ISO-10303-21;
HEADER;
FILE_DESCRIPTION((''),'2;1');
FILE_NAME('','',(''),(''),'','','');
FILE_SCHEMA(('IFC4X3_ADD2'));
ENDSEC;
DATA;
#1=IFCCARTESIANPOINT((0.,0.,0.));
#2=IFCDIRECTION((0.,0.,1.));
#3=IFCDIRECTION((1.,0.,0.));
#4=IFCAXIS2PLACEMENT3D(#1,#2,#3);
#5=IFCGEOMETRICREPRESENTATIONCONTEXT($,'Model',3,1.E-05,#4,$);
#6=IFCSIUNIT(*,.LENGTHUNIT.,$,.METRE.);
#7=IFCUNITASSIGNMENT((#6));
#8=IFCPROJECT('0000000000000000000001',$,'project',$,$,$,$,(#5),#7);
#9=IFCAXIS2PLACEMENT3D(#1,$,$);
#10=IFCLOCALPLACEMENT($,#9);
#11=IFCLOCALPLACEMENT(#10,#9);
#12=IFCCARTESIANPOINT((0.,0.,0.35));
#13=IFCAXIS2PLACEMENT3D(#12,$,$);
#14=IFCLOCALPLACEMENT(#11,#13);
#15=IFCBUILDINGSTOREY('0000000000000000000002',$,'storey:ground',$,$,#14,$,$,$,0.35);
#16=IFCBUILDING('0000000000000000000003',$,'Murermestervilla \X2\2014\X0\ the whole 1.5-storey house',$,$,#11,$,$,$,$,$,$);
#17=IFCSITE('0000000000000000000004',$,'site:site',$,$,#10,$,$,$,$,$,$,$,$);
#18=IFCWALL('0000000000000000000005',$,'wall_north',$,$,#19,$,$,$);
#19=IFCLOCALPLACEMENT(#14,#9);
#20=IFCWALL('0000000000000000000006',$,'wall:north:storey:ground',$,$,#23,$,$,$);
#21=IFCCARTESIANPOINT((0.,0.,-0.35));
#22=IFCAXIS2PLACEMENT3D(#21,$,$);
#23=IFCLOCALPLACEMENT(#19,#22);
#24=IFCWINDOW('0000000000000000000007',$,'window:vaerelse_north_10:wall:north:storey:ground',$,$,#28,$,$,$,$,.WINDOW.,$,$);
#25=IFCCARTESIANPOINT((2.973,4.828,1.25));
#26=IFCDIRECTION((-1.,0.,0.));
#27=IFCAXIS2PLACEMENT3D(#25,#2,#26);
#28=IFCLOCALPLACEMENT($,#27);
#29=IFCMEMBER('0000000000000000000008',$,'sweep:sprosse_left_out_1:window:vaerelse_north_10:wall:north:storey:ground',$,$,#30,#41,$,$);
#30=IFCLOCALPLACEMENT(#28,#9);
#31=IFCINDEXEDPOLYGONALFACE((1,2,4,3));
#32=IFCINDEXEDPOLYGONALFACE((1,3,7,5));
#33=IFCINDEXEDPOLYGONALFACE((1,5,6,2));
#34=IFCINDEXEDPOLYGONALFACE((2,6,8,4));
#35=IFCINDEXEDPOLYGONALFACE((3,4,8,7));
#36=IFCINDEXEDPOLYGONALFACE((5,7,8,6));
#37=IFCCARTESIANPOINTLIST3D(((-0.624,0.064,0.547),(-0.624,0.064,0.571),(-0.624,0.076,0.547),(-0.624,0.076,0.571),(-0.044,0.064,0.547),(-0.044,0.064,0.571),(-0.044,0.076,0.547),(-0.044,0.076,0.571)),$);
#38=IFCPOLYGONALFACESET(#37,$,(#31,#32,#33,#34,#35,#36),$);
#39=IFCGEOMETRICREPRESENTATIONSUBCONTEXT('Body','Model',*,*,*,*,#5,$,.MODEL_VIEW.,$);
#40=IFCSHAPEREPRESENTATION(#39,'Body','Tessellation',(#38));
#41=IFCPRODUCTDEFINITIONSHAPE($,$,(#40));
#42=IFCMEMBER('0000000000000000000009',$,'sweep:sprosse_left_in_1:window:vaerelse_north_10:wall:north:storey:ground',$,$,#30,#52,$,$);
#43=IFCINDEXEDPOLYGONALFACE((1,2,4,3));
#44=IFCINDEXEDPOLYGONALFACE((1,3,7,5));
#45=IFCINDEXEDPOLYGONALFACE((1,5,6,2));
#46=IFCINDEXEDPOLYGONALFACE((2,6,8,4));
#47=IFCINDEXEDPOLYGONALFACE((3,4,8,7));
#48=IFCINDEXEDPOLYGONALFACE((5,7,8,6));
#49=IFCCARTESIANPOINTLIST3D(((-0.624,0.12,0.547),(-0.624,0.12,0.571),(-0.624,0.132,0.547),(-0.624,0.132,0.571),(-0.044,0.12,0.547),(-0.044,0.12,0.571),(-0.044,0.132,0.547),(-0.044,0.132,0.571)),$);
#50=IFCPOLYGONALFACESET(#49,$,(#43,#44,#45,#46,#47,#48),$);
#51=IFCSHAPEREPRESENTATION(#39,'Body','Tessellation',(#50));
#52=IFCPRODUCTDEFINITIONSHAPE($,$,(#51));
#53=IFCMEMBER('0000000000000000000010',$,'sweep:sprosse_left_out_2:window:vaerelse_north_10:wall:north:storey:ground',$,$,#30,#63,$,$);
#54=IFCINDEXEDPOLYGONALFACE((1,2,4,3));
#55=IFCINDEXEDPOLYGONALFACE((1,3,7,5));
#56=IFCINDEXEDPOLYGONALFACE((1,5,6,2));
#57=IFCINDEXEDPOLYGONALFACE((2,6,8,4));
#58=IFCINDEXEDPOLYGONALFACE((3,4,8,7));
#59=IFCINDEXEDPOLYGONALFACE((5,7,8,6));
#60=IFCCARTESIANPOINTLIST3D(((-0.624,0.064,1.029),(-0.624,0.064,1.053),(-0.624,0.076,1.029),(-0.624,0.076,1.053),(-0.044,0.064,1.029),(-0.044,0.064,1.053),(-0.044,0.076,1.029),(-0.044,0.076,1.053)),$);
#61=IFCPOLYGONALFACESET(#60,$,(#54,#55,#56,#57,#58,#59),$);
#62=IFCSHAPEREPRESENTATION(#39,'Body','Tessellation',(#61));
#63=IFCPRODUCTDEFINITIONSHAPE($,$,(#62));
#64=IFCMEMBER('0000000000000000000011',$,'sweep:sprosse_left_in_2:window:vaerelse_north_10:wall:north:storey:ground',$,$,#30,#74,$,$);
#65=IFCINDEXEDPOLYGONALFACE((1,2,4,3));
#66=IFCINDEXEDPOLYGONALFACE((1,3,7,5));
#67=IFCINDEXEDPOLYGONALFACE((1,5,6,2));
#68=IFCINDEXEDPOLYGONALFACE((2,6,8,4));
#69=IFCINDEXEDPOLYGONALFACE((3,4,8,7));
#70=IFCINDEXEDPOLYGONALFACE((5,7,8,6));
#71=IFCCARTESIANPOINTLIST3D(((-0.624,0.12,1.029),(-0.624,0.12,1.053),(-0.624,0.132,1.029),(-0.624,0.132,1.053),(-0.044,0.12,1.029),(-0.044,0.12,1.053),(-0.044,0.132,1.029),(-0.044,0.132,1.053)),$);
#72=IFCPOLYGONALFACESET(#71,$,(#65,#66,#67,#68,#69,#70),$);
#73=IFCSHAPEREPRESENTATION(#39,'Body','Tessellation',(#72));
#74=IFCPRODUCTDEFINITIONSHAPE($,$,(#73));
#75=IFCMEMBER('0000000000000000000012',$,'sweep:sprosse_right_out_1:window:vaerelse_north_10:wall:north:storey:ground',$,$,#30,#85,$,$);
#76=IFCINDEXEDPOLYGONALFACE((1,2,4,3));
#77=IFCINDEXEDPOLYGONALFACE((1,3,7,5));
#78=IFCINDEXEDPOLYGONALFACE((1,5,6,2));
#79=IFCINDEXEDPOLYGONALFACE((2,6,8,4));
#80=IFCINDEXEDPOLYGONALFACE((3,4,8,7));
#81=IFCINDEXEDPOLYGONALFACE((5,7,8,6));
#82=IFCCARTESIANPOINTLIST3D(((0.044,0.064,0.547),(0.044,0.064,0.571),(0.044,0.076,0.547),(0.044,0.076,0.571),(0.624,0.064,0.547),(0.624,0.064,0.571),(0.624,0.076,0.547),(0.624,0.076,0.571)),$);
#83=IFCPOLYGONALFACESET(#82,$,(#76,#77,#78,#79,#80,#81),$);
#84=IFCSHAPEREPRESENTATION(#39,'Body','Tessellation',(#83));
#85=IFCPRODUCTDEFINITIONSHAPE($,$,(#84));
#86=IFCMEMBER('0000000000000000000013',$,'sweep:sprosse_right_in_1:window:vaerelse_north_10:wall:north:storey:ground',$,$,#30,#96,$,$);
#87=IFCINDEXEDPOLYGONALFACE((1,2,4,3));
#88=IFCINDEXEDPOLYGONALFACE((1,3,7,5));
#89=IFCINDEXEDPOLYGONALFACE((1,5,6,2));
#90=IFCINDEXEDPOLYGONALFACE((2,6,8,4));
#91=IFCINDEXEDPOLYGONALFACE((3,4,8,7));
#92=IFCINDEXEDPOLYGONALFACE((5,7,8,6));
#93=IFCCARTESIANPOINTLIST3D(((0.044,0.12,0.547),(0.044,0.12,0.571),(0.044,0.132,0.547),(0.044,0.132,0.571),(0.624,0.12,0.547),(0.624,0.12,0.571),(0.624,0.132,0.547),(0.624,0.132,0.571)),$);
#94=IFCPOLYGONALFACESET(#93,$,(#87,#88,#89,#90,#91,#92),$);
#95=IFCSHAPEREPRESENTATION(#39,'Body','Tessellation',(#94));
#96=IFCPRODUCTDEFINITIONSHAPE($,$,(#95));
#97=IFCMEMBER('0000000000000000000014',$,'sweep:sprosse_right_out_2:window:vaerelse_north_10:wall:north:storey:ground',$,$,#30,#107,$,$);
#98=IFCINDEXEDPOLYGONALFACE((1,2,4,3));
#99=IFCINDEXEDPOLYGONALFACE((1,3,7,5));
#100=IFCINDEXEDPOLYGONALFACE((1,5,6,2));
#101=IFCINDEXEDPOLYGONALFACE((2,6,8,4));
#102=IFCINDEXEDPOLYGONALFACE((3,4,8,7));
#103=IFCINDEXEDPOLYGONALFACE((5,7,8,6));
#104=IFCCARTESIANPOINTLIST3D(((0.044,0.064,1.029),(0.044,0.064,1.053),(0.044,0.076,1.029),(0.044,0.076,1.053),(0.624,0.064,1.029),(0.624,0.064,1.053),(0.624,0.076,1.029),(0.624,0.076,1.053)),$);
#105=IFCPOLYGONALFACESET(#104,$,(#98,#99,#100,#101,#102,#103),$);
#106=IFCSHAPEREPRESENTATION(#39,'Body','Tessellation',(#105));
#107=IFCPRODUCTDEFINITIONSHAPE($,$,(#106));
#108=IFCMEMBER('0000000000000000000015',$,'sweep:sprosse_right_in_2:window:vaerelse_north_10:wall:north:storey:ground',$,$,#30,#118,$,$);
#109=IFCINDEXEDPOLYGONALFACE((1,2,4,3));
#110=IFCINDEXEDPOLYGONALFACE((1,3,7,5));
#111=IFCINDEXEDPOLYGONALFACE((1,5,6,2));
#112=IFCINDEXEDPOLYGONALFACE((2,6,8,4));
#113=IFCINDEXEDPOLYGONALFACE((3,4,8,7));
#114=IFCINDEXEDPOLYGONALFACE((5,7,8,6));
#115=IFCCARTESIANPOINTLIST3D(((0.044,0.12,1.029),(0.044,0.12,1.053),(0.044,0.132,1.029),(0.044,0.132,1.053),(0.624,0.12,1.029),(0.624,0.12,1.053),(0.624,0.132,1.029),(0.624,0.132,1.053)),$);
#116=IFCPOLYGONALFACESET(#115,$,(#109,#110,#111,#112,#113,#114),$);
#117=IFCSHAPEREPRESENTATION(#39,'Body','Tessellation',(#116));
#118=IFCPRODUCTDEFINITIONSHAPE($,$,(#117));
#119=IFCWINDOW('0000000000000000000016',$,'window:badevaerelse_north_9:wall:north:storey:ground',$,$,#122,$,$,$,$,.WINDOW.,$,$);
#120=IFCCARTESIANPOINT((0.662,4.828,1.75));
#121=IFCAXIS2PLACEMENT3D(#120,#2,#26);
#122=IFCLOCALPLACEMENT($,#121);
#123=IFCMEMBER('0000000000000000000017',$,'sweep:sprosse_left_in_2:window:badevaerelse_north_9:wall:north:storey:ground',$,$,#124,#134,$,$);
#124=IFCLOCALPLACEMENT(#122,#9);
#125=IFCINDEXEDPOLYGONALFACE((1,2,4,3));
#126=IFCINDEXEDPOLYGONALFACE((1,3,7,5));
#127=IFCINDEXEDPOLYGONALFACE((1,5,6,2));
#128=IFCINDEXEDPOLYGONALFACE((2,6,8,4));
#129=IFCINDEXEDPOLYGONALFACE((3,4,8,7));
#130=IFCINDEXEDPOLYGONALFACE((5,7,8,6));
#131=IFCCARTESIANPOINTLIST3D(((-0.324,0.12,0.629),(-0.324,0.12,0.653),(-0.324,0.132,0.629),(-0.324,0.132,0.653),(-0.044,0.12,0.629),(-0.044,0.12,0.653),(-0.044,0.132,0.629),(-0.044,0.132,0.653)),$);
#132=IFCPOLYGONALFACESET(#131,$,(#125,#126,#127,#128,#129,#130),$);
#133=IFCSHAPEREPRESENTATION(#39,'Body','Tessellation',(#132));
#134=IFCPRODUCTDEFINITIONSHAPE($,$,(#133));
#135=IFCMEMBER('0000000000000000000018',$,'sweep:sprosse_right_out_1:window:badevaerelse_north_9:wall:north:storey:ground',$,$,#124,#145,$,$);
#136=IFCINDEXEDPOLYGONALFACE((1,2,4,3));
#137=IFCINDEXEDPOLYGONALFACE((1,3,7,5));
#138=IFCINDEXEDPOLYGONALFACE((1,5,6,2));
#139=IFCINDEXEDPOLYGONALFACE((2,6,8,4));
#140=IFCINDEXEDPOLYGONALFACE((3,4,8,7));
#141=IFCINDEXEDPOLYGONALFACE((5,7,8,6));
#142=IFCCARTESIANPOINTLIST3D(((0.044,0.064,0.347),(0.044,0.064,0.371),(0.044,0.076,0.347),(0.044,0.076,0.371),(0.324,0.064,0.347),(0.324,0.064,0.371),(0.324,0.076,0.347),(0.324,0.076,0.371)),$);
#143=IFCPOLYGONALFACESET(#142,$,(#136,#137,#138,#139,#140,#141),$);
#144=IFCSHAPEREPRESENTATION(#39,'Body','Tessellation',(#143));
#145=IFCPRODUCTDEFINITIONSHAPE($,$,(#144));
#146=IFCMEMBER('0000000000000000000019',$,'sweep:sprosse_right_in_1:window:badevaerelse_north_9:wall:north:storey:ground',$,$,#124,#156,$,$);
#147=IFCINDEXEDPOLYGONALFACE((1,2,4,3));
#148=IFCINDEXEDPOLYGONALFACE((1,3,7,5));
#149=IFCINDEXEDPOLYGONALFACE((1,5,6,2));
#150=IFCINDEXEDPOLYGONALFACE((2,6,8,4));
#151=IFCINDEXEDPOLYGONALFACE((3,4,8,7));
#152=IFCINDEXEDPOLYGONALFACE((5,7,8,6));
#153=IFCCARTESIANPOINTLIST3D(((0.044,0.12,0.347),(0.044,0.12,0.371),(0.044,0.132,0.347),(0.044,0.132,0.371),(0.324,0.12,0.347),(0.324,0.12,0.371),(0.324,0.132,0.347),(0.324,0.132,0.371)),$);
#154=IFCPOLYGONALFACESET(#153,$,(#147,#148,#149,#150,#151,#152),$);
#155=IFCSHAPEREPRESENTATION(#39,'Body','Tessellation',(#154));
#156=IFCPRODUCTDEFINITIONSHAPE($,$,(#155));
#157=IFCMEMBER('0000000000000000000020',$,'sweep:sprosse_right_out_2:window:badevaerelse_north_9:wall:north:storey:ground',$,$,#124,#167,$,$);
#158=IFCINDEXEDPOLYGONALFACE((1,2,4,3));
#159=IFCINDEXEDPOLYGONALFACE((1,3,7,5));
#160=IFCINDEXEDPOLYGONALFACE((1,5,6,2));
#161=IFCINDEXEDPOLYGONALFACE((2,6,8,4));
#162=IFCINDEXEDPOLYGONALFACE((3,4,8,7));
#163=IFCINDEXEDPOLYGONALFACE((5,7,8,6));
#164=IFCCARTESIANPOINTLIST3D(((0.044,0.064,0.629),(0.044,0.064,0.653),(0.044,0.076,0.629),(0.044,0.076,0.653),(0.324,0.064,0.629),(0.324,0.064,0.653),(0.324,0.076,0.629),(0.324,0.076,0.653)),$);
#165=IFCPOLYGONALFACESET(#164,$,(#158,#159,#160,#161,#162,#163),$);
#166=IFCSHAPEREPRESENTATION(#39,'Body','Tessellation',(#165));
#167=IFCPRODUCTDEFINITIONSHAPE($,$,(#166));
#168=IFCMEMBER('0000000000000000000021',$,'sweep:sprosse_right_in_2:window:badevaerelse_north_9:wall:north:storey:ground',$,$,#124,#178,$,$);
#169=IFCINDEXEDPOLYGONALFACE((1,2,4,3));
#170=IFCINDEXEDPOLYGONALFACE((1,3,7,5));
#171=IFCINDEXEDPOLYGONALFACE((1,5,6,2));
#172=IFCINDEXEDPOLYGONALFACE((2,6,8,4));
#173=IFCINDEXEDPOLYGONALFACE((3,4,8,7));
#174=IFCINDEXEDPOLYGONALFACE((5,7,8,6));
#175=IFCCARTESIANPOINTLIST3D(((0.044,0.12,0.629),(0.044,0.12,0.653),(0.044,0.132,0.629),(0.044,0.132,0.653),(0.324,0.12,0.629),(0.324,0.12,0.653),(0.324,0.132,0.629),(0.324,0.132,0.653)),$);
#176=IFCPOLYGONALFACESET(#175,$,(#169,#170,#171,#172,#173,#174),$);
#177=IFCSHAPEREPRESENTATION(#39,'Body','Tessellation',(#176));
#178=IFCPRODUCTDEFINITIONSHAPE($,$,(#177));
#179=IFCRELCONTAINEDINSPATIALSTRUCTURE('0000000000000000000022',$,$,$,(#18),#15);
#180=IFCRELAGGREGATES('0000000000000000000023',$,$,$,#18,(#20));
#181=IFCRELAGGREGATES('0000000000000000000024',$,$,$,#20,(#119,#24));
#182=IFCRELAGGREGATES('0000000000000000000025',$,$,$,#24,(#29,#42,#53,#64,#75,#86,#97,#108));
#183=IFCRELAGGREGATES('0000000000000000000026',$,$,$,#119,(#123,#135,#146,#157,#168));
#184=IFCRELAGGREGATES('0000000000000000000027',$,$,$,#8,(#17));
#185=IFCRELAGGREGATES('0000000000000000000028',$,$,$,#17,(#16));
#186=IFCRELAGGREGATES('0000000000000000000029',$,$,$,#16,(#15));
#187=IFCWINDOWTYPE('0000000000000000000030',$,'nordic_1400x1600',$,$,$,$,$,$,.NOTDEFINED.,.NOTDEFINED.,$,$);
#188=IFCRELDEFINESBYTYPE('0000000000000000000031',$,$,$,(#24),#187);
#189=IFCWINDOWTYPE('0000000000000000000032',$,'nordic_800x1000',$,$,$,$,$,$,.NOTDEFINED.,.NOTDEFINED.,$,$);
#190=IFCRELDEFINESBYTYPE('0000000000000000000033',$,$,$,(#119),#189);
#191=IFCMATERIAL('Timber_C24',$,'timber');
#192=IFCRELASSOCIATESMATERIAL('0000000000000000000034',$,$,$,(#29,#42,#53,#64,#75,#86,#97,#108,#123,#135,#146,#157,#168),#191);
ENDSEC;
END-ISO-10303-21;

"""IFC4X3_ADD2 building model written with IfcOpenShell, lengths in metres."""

from ifc_helpers import new_model, si_unit, frame, origin, origin_with_axes, place, context, subcontext, project, spatial, polyline, outline, extrude, source, transform, mapped, material, type_object, element, aggregate, save


model = new_model("IFC4X3_ADD2")

# Units and contexts
model_context = context("Model", 3, precision=1e-05, world=origin_with_axes())
body_context = subcontext(model_context, "Body", "Model", "MODEL_VIEW")
ifc_project = project(units=[si_unit("LENGTHUNIT", "METRE")], contexts=[model_context])

# Site, building, storey
site_placement = place(None, origin())
site = spatial("IfcSite", under=ifc_project, at=site_placement, Name="site:site")
building_placement = place(site_placement, origin())
building = spatial("IfcBuilding", under=site, at=building_placement, Name="Murermestervilla — the whole 1.5-storey house")
storey_placement = place(building_placement, frame((0.0, 0.0, 0.35)))
storey = spatial("IfcBuildingStorey", under=building, at=storey_placement, Name="storey:ground", Elevation=0.35)

# Walls, windows, members
wall_1_placement = place(storey_placement, origin())
wall_1 = element("IfcWall", 1, at=wall_1_placement, inside=storey, Name="wall_north")
wall_2_placement = place(wall_1_placement, frame((0.0, 0.0, -0.35)))
wall_2 = element("IfcWall", 2, at=wall_2_placement, Name="wall:north:storey:ground")
aggregate(wall_1, [wall_2])
window_type_1 = type_object("IfcWindowType", Name="nordic_1400x1600", PartitioningType="NOTDEFINED", PredefinedType="NOTDEFINED")
window_1_placement = place(None, frame((2.973, 4.828, 1.25), z_axis=(0.0, 0.0, 1.0), x_axis=(-1.0, 0.0, 0.0)))
window_1 = element("IfcWindow", 3, at=window_1_placement, type_object=window_type_1, Name="window:vaerelse_north_10:wall:north:storey:ground", PredefinedType="WINDOW")
ifc_material_1 = material(Name="Timber_C24", Category="timber")
placement_1 = place(window_1_placement, origin())
shared_shape_1 = source(origin(), body_context, "Body", "SweptSolid", [
    extrude(outline(polyline([(-0.006, -0.012), (0.006, -0.012), (0.006, 0.012), (-0.006, 0.012), (-0.006, -0.012)])), frame((-0.624, 0.07, 0.559), z_axis=(1.0, 0.0, 0.0), x_axis=(0.0, 1.0, 0.0)), (0.0, 0.0, 1.0), 0.58),
])
member_1 = element("IfcMember", 4, at=placement_1, material=ifc_material_1, Name="sweep:sprosse_left_out_1:window:vaerelse_north_10:wall:north:storey:ground", context=body_context, shape_type="MappedRepresentation", body=[
    mapped(shared_shape_1, transform((0.0, 0.0, 0.0))),
])
shared_shape_2 = source(origin(), body_context, "Body", "SweptSolid", [
    extrude(outline(polyline([(-0.006, -0.012), (0.006, -0.012), (0.006, 0.012), (-0.006, 0.012), (-0.006, -0.012)])), frame((-0.624, 0.126, 0.559), z_axis=(1.0, 0.0, 0.0), x_axis=(0.0, 1.0, 0.0)), (0.0, 0.0, 1.0), 0.58),
])
member_2 = element("IfcMember", 5, at=placement_1, material=ifc_material_1, Name="sweep:sprosse_left_in_1:window:vaerelse_north_10:wall:north:storey:ground", context=body_context, shape_type="MappedRepresentation", body=[
    mapped(shared_shape_2, transform((0.0, 0.0, 0.0))),
])
shared_shape_3 = source(origin(), body_context, "Body", "SweptSolid", [
    extrude(outline(polyline([(-0.006, -0.012), (0.006, -0.012), (0.006, 0.012), (-0.006, 0.012), (-0.006, -0.012)])), frame((-0.624, 0.07, 1.041), z_axis=(1.0, 0.0, 0.0), x_axis=(0.0, 1.0, 0.0)), (0.0, 0.0, 1.0), 0.58),
])
member_3 = element("IfcMember", 6, at=placement_1, material=ifc_material_1, Name="sweep:sprosse_left_out_2:window:vaerelse_north_10:wall:north:storey:ground", context=body_context, shape_type="MappedRepresentation", body=[
    mapped(shared_shape_3, transform((0.0, 0.0, 0.0))),
])
shared_shape_4 = source(origin(), body_context, "Body", "SweptSolid", [
    extrude(outline(polyline([(-0.006, -0.012), (0.006, -0.012), (0.006, 0.012), (-0.006, 0.012), (-0.006, -0.012)])), frame((-0.624, 0.126, 1.041), z_axis=(1.0, 0.0, 0.0), x_axis=(0.0, 1.0, 0.0)), (0.0, 0.0, 1.0), 0.58),
])
member_4 = element("IfcMember", 7, at=placement_1, material=ifc_material_1, Name="sweep:sprosse_left_in_2:window:vaerelse_north_10:wall:north:storey:ground", context=body_context, shape_type="MappedRepresentation", body=[
    mapped(shared_shape_4, transform((0.0, 0.0, 0.0))),
])
shared_shape_5 = source(origin(), body_context, "Body", "SweptSolid", [
    extrude(outline(polyline([(-0.006, -0.012), (0.006, -0.012), (0.006, 0.012), (-0.006, 0.012), (-0.006, -0.012)])), frame((0.044, 0.07, 0.559), z_axis=(1.0, 0.0, 0.0), x_axis=(0.0, 1.0, 0.0)), (0.0, 0.0, 1.0), 0.58),
])
member_5 = element("IfcMember", 8, at=placement_1, material=ifc_material_1, Name="sweep:sprosse_right_out_1:window:vaerelse_north_10:wall:north:storey:ground", context=body_context, shape_type="MappedRepresentation", body=[
    mapped(shared_shape_5, transform((0.0, 0.0, 0.0))),
])
shared_shape_6 = source(origin(), body_context, "Body", "SweptSolid", [
    extrude(outline(polyline([(-0.006, -0.012), (0.006, -0.012), (0.006, 0.012), (-0.006, 0.012), (-0.006, -0.012)])), frame((0.044, 0.126, 0.559), z_axis=(1.0, 0.0, 0.0), x_axis=(0.0, 1.0, 0.0)), (0.0, 0.0, 1.0), 0.58),
])
member_6 = element("IfcMember", 9, at=placement_1, material=ifc_material_1, Name="sweep:sprosse_right_in_1:window:vaerelse_north_10:wall:north:storey:ground", context=body_context, shape_type="MappedRepresentation", body=[
    mapped(shared_shape_6, transform((0.0, 0.0, 0.0))),
])
shared_shape_7 = source(origin(), body_context, "Body", "SweptSolid", [
    extrude(outline(polyline([(-0.006, -0.012), (0.006, -0.012), (0.006, 0.012), (-0.006, 0.012), (-0.006, -0.012)])), frame((0.044, 0.07, 1.041), z_axis=(1.0, 0.0, 0.0), x_axis=(0.0, 1.0, 0.0)), (0.0, 0.0, 1.0), 0.58),
])
member_7 = element("IfcMember", 10, at=placement_1, material=ifc_material_1, Name="sweep:sprosse_right_out_2:window:vaerelse_north_10:wall:north:storey:ground", context=body_context, shape_type="MappedRepresentation", body=[
    mapped(shared_shape_7, transform((0.0, 0.0, 0.0))),
])
shared_shape_8 = source(origin(), body_context, "Body", "SweptSolid", [
    extrude(outline(polyline([(-0.006, -0.012), (0.006, -0.012), (0.006, 0.012), (-0.006, 0.012), (-0.006, -0.012)])), frame((0.044, 0.126, 1.041), z_axis=(1.0, 0.0, 0.0), x_axis=(0.0, 1.0, 0.0)), (0.0, 0.0, 1.0), 0.58),
])
member_8 = element("IfcMember", 11, at=placement_1, material=ifc_material_1, Name="sweep:sprosse_right_in_2:window:vaerelse_north_10:wall:north:storey:ground", context=body_context, shape_type="MappedRepresentation", body=[
    mapped(shared_shape_8, transform((0.0, 0.0, 0.0))),
])
window_type_2 = type_object("IfcWindowType", Name="nordic_800x1000", PartitioningType="NOTDEFINED", PredefinedType="NOTDEFINED")
window_2_placement = place(None, frame((0.662, 4.828, 1.75), z_axis=(0.0, 0.0, 1.0), x_axis=(-1.0, 0.0, 0.0)))
window_2 = element("IfcWindow", 12, at=window_2_placement, type_object=window_type_2, Name="window:badevaerelse_north_9:wall:north:storey:ground", PredefinedType="WINDOW")
aggregate(wall_2, [window_2, window_1])
shared_shape_9 = source(origin(), body_context, "Body", "SweptSolid", [
    extrude(outline(polyline([(-0.006, -0.012), (0.006, -0.012), (0.006, 0.012), (-0.006, 0.012), (-0.006, -0.012)])), frame((-0.324, 0.126, 0.641), z_axis=(1.0, 0.0, 0.0), x_axis=(0.0, 1.0, 0.0)), (0.0, 0.0, 1.0), 0.28),
])
placement_2 = place(window_2_placement, origin())
member_9 = element("IfcMember", 13, at=placement_2, material=ifc_material_1, Name="sweep:sprosse_left_in_2:window:badevaerelse_north_9:wall:north:storey:ground", context=body_context, shape_type="MappedRepresentation", body=[
    mapped(shared_shape_9, transform((0.0, 0.0, 0.0))),
])
shared_shape_10 = source(origin(), body_context, "Body", "SweptSolid", [
    extrude(outline(polyline([(-0.006, -0.012), (0.006, -0.012), (0.006, 0.012), (-0.006, 0.012), (-0.006, -0.012)])), frame((0.044, 0.07, 0.359), z_axis=(1.0, 0.0, 0.0), x_axis=(0.0, 1.0, 0.0)), (0.0, 0.0, 1.0), 0.28),
])
member_10 = element("IfcMember", 14, at=placement_2, material=ifc_material_1, Name="sweep:sprosse_right_out_1:window:badevaerelse_north_9:wall:north:storey:ground", context=body_context, shape_type="MappedRepresentation", body=[
    mapped(shared_shape_10, transform((0.0, 0.0, 0.0))),
])
shared_shape_11 = source(origin(), body_context, "Body", "SweptSolid", [
    extrude(outline(polyline([(-0.006, -0.012), (0.006, -0.012), (0.006, 0.012), (-0.006, 0.012), (-0.006, -0.012)])), frame((0.044, 0.126, 0.359), z_axis=(1.0, 0.0, 0.0), x_axis=(0.0, 1.0, 0.0)), (0.0, 0.0, 1.0), 0.28),
])
member_11 = element("IfcMember", 15, at=placement_2, material=ifc_material_1, Name="sweep:sprosse_right_in_1:window:badevaerelse_north_9:wall:north:storey:ground", context=body_context, shape_type="MappedRepresentation", body=[
    mapped(shared_shape_11, transform((0.0, 0.0, 0.0))),
])
shared_shape_12 = source(origin(), body_context, "Body", "SweptSolid", [
    extrude(outline(polyline([(-0.006, -0.012), (0.006, -0.012), (0.006, 0.012), (-0.006, 0.012), (-0.006, -0.012)])), frame((0.044, 0.07, 0.641), z_axis=(1.0, 0.0, 0.0), x_axis=(0.0, 1.0, 0.0)), (0.0, 0.0, 1.0), 0.28),
])
member_12 = element("IfcMember", 16, at=placement_2, material=ifc_material_1, Name="sweep:sprosse_right_out_2:window:badevaerelse_north_9:wall:north:storey:ground", context=body_context, shape_type="MappedRepresentation", body=[
    mapped(shared_shape_12, transform((0.0, 0.0, 0.0))),
])
shared_shape_13 = source(origin(), body_context, "Body", "SweptSolid", [
    extrude(outline(polyline([(-0.006, -0.012), (0.006, -0.012), (0.006, 0.012), (-0.006, 0.012), (-0.006, -0.012)])), frame((0.044, 0.126, 0.641), z_axis=(1.0, 0.0, 0.0), x_axis=(0.0, 1.0, 0.0)), (0.0, 0.0, 1.0), 0.28),
])
member_13 = element("IfcMember", 17, at=placement_2, material=ifc_material_1, Name="sweep:sprosse_right_in_2:window:badevaerelse_north_9:wall:north:storey:ground", context=body_context, shape_type="MappedRepresentation", body=[
    mapped(shared_shape_13, transform((0.0, 0.0, 0.0))),
])

aggregate(window_1, [member_1, member_2, member_3, member_4, member_5, member_6, member_7, member_8])
aggregate(window_2, [member_9, member_10, member_11, member_12, member_13])

save(model, "model.ifc")
